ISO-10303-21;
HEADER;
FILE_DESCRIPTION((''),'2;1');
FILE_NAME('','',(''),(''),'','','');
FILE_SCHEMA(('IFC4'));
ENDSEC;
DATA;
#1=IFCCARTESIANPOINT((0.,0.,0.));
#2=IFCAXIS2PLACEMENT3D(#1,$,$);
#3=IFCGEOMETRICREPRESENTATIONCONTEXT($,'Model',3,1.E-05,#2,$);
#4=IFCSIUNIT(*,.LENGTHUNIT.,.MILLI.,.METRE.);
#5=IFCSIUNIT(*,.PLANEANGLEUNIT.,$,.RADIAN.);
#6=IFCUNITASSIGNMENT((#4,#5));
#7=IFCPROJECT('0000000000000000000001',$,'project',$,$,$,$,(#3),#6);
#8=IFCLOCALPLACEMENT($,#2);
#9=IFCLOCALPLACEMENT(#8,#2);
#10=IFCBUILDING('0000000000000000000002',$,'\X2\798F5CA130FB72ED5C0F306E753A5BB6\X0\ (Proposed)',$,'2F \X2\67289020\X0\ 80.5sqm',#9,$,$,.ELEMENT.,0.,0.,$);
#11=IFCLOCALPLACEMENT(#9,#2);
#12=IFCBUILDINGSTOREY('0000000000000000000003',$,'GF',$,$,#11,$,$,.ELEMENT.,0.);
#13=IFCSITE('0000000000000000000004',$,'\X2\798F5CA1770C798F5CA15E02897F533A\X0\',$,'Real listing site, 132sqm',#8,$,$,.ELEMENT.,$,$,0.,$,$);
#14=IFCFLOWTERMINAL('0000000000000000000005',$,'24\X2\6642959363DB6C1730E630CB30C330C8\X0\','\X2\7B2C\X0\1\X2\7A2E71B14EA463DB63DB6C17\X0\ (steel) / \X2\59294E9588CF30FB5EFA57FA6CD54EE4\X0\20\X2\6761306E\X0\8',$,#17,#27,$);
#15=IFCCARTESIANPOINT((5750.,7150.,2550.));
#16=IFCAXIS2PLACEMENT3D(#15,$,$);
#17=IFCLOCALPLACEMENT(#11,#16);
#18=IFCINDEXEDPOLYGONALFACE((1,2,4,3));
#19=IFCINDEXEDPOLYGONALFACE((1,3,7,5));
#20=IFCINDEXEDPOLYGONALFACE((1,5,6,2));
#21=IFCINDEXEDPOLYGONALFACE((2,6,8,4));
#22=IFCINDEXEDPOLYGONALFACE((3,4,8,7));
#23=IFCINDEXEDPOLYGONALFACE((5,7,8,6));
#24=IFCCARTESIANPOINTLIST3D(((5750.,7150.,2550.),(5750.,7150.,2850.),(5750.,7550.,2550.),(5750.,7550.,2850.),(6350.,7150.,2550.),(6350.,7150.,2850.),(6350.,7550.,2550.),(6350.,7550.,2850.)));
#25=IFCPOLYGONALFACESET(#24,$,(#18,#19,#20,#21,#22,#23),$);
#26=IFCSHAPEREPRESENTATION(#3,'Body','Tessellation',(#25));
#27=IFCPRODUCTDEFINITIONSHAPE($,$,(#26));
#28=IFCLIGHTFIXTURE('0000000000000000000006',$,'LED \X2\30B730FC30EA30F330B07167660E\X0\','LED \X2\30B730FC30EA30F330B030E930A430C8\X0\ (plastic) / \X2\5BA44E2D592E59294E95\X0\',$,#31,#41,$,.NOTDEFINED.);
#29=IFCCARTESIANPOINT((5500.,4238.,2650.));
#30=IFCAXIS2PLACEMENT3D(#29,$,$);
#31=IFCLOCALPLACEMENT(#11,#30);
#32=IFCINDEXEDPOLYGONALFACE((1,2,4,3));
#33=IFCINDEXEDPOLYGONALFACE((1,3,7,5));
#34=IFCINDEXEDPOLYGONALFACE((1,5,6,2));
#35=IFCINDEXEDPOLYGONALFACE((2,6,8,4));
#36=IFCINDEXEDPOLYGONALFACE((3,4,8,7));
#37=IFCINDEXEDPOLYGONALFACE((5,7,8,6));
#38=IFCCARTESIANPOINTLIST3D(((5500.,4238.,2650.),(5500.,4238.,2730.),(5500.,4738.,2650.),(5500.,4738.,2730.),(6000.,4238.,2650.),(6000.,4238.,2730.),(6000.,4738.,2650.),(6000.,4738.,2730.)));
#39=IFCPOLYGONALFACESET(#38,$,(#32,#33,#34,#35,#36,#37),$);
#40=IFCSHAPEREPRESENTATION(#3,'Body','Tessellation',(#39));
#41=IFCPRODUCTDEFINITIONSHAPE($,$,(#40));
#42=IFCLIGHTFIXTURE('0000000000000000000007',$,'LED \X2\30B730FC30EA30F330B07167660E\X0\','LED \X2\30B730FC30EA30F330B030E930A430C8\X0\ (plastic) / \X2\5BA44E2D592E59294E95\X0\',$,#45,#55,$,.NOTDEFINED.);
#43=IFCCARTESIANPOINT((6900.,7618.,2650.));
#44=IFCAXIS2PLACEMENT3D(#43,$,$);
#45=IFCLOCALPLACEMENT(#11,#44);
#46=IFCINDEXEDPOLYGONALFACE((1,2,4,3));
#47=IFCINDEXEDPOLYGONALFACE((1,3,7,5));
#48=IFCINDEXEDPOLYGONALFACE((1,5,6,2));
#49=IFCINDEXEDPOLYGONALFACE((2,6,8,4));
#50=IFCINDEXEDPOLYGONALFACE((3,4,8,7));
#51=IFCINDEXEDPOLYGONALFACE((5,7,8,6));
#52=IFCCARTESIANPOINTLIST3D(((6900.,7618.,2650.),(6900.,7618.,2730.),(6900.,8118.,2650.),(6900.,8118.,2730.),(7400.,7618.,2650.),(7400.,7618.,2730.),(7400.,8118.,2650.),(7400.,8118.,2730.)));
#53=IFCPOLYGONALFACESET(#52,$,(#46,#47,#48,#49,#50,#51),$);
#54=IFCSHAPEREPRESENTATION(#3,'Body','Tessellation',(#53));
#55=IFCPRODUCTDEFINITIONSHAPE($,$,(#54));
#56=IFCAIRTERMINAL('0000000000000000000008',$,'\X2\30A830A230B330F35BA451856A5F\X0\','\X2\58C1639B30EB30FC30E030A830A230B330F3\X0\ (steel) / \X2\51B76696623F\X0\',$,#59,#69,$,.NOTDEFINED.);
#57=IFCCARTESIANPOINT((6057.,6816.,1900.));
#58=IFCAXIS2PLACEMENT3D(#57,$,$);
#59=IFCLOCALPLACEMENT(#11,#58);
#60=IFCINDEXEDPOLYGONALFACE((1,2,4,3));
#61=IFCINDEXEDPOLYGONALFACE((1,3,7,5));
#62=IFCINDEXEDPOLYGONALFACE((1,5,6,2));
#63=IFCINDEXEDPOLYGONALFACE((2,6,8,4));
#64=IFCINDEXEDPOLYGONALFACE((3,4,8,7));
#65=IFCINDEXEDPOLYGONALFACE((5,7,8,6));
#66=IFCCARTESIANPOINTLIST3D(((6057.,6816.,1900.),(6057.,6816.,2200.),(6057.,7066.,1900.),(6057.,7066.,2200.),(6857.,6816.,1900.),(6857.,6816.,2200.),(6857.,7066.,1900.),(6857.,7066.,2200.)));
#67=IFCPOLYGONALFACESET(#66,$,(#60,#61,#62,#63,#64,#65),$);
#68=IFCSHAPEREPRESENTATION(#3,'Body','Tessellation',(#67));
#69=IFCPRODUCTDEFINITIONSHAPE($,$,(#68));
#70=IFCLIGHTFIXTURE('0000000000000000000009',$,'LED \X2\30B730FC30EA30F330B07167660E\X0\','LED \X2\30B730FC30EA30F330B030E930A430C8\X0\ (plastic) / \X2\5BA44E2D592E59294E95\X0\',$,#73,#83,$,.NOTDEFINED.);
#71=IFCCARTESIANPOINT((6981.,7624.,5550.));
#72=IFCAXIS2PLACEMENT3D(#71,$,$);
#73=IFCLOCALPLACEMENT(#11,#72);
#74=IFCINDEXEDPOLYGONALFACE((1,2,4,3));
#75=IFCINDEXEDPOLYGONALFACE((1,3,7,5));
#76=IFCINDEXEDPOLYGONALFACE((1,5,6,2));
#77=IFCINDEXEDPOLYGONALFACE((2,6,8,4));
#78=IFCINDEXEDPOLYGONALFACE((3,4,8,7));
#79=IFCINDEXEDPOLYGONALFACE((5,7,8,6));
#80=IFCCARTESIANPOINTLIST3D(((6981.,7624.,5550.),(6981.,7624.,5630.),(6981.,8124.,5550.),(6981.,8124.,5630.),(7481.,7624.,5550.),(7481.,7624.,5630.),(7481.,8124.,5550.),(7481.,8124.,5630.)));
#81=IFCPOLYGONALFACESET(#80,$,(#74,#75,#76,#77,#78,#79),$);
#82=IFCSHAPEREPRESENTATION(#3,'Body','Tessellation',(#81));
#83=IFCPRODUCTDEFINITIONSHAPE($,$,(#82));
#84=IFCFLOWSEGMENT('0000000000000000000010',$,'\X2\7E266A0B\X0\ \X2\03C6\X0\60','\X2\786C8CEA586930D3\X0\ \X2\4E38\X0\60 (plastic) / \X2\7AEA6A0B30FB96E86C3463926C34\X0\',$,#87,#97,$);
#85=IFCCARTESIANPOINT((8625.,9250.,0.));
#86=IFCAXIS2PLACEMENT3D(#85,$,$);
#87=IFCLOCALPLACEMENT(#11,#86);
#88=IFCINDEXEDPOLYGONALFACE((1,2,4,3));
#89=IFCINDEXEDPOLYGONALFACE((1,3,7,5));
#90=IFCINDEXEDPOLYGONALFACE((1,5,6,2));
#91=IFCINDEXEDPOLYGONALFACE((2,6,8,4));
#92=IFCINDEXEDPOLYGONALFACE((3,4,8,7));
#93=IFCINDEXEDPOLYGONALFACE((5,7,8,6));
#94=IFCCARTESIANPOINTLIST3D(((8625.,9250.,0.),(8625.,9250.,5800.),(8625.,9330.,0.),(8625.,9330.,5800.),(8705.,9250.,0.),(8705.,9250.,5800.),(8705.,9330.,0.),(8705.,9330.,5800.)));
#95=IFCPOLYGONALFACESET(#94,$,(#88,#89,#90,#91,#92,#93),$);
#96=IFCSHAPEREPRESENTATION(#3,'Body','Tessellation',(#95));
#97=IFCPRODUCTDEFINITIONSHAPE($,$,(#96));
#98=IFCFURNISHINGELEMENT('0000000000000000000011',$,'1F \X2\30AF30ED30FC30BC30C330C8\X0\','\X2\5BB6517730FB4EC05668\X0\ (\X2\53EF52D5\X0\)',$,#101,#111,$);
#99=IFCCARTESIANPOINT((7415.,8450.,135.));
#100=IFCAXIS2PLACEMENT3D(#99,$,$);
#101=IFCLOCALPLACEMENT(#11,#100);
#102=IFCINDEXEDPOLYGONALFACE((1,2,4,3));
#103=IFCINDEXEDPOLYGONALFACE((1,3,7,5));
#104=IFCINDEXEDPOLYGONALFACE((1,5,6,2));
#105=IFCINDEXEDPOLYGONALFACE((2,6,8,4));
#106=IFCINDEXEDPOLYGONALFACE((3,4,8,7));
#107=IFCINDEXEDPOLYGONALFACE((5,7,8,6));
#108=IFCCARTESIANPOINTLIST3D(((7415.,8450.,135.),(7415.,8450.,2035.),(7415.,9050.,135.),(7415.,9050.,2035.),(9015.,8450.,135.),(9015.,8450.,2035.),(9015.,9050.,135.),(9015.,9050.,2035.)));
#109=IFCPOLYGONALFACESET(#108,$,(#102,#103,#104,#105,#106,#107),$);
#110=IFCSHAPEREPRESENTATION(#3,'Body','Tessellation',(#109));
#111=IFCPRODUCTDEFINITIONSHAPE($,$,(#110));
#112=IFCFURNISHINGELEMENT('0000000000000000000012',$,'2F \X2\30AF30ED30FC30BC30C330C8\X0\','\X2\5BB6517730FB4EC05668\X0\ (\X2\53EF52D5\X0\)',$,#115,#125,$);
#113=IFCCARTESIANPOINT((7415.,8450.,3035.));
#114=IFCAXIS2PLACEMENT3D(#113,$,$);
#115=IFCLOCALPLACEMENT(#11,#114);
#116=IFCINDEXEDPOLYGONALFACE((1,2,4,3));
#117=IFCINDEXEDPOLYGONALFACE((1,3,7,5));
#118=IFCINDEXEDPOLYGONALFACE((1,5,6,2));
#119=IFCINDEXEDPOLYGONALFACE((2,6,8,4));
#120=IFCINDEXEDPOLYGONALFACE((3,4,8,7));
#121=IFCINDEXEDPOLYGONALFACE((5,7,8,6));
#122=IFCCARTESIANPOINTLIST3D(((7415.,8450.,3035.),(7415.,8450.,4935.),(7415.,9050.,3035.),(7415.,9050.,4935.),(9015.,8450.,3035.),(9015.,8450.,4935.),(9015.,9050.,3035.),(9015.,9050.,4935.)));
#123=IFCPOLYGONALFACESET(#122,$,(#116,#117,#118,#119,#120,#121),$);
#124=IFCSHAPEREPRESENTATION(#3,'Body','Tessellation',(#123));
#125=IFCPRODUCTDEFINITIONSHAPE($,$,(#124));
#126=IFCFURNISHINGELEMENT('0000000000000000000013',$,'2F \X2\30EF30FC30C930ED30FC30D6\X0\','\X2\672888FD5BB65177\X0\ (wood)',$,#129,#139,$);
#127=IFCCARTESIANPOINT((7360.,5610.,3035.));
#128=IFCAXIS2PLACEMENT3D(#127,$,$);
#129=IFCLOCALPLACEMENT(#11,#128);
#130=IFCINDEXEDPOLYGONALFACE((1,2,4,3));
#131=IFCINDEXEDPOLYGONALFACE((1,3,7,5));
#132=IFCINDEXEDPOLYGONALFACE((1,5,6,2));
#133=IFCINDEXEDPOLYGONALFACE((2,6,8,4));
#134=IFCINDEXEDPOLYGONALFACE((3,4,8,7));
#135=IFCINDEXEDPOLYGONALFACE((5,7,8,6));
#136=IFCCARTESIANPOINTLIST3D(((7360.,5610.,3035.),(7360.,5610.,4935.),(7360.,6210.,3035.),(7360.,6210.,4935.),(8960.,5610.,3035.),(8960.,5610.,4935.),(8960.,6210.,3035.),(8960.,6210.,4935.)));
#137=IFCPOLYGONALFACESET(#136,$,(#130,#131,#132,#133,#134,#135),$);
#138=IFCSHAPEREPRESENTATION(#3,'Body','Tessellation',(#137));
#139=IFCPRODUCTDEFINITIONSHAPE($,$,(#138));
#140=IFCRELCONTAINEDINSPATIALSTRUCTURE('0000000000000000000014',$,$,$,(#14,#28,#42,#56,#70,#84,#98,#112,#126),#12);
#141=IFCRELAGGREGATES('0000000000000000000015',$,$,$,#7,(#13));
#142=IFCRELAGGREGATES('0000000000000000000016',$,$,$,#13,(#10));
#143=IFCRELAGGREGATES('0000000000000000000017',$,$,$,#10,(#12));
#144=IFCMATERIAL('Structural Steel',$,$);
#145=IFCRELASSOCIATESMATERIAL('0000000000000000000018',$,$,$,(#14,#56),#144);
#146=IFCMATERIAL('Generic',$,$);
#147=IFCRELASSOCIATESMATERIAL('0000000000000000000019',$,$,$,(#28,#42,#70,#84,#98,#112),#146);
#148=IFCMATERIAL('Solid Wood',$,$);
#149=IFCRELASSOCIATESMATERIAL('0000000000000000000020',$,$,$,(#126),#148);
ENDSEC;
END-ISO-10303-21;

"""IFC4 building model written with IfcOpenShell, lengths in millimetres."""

from ifc_helpers import new_model, si_unit, frame, frame_2d, origin, place, context, project, spatial, rectangle, extrude, material, element, save


model = new_model("IFC4")

# Units and contexts
model_context = context("Model", 3, precision=1e-05, world=origin())
ifc_project = project(units=[si_unit("LENGTHUNIT", "METRE", prefix="MILLI"), si_unit("PLANEANGLEUNIT", "RADIAN")], contexts=[model_context])

# Site, building, storey
site_placement = place(None, origin())
site = spatial("IfcSite", under=ifc_project, at=site_placement, Name="福岡県福岡市西区", ObjectType="Real listing site, 132sqm", CompositionType="ELEMENT", RefElevation=0.0)
building_placement = place(site_placement, origin())
building = spatial("IfcBuilding", under=site, at=building_placement, Name="福岡・狭小の町家 (Proposed)", ObjectType="2F 木造 80.5sqm", CompositionType="ELEMENT", ElevationOfRefHeight=0.0, ElevationOfTerrain=0.0)
storey_placement = place(building_placement, origin())
storey = spatial("IfcBuildingStorey", under=building, at=storey_placement, Name="GF", CompositionType="ELEMENT", Elevation=0.0)

# Shared definitions
ifc_material_1 = material(Name="Solid Wood")

# Shared definitions
ifc_material_2 = material(Name="Structural Steel")

# Shared definitions
ifc_material_3 = material(Name="Generic")

# Flow terminal
flow_terminal_placement = place(storey_placement, frame((5750.0, 7150.0, 2550.0)))
element("IfcFlowTerminal", 1, at=flow_terminal_placement, inside=storey, material=ifc_material_2, Name="24時間換気ユニット", Description="第1種熱交換換気 (steel) / 天井裏・建基法令20条の8", context=model_context, shape_type="SweptSolid", body=[
    extrude(rectangle(XDim=600.0, YDim=400.0, at=frame_2d((300.0, 200.0))), frame((5750.0, 7150.0, 2550.0)), (0.0, 0.0, 1.0), 300.0),
])

# Light fixtures
light_fixture_1_placement = place(storey_placement, frame((5500.0, 4238.0, 2650.0)))
element("IfcLightFixture", 2, at=light_fixture_1_placement, inside=storey, material=ifc_material_3, Name="LED シーリング照明", Description="LED シーリングライト (plastic) / 室中央天井", PredefinedType="NOTDEFINED", context=model_context, shape_type="SweptSolid", body=[
    extrude(rectangle(XDim=500.0, YDim=500.0, at=frame_2d((250.0, 250.0))), frame((5500.0, 4238.0, 2650.0)), (0.0, 0.0, 1.0), 80.0),
])
light_fixture_2_placement = place(storey_placement, frame((6900.0, 7618.0, 2650.0)))
element("IfcLightFixture", 3, at=light_fixture_2_placement, inside=storey, material=ifc_material_3, Name="LED シーリング照明", Description="LED シーリングライト (plastic) / 室中央天井", PredefinedType="NOTDEFINED", context=model_context, shape_type="SweptSolid", body=[
    extrude(rectangle(XDim=500.0, YDim=500.0, at=frame_2d((250.0, 250.0))), frame((6900.0, 7618.0, 2650.0)), (0.0, 0.0, 1.0), 80.0),
])

# Air terminal
air_terminal_placement = place(storey_placement, frame((6057.0, 6816.0, 1900.0)))
element("IfcAirTerminal", 4, at=air_terminal_placement, inside=storey, material=ifc_material_2, Name="エアコン室内機", Description="壁掛ルームエアコン (steel) / 冷暖房", PredefinedType="NOTDEFINED", context=model_context, shape_type="SweptSolid", body=[
    extrude(rectangle(XDim=800.0, YDim=250.0, at=frame_2d((400.0, 125.0))), frame((6057.0, 6816.0, 1900.0)), (0.0, 0.0, 1.0), 300.0),
])

# Light fixture
light_fixture_3_placement = place(storey_placement, frame((6981.0, 7624.0, 5550.0)))
element("IfcLightFixture", 5, at=light_fixture_3_placement, inside=storey, material=ifc_material_3, Name="LED シーリング照明", Description="LED シーリングライト (plastic) / 室中央天井", PredefinedType="NOTDEFINED", context=model_context, shape_type="SweptSolid", body=[
    extrude(rectangle(XDim=500.0, YDim=500.0, at=frame_2d((250.0, 250.0))), frame((6981.0, 7624.0, 5550.0)), (0.0, 0.0, 1.0), 80.0),
])

# Flow segment
flow_segment_placement = place(storey_placement, frame((8625.0, 9250.0, 0.0)))
element("IfcFlowSegment", 6, at=flow_segment_placement, inside=storey, material=ifc_material_3, Name="縦樋 φ60", Description="硬質塩ビ 丸60 (plastic) / 竪樋・雨水排水", context=model_context, shape_type="SweptSolid", body=[
    extrude(rectangle(XDim=80.0, YDim=80.0, at=frame_2d((40.0, 40.0))), frame((8625.0, 9250.0, 0.0)), (0.0, 0.0, 1.0), 5800.0),
])

# Furnishing elements
furnishing_1_placement = place(storey_placement, frame((7415.0, 8450.0, 135.0)))
element("IfcFurnishingElement", 7, at=furnishing_1_placement, inside=storey, material=ifc_material_3, Name="1F クローゼット", Description="家具・什器 (可動)", context=model_context, shape_type="SweptSolid", body=[
    extrude(rectangle(XDim=1600.0, YDim=600.0, at=frame_2d((800.0, 300.0))), frame((7415.0, 8450.0, 135.0)), (0.0, 0.0, 1.0), 1900.0),
])
furnishing_2_placement = place(storey_placement, frame((7415.0, 8450.0, 3035.0)))
element("IfcFurnishingElement", 8, at=furnishing_2_placement, inside=storey, material=ifc_material_3, Name="2F クローゼット", Description="家具・什器 (可動)", context=model_context, shape_type="SweptSolid", body=[
    extrude(rectangle(XDim=1600.0, YDim=600.0, at=frame_2d((800.0, 300.0))), frame((7415.0, 8450.0, 3035.0)), (0.0, 0.0, 1.0), 1900.0),
])
furnishing_3_placement = place(storey_placement, frame((7360.0, 5610.0, 3035.0)))
element("IfcFurnishingElement", 9, at=furnishing_3_placement, inside=storey, material=ifc_material_1, Name="2F ワードローブ", Description="木製家具 (wood)", context=model_context, shape_type="SweptSolid", body=[
    extrude(rectangle(XDim=1600.0, YDim=600.0, at=frame_2d((800.0, 300.0))), frame((7360.0, 5610.0, 3035.0)), (0.0, 0.0, 1.0), 1900.0),
])

save(model, "model.ifc")
